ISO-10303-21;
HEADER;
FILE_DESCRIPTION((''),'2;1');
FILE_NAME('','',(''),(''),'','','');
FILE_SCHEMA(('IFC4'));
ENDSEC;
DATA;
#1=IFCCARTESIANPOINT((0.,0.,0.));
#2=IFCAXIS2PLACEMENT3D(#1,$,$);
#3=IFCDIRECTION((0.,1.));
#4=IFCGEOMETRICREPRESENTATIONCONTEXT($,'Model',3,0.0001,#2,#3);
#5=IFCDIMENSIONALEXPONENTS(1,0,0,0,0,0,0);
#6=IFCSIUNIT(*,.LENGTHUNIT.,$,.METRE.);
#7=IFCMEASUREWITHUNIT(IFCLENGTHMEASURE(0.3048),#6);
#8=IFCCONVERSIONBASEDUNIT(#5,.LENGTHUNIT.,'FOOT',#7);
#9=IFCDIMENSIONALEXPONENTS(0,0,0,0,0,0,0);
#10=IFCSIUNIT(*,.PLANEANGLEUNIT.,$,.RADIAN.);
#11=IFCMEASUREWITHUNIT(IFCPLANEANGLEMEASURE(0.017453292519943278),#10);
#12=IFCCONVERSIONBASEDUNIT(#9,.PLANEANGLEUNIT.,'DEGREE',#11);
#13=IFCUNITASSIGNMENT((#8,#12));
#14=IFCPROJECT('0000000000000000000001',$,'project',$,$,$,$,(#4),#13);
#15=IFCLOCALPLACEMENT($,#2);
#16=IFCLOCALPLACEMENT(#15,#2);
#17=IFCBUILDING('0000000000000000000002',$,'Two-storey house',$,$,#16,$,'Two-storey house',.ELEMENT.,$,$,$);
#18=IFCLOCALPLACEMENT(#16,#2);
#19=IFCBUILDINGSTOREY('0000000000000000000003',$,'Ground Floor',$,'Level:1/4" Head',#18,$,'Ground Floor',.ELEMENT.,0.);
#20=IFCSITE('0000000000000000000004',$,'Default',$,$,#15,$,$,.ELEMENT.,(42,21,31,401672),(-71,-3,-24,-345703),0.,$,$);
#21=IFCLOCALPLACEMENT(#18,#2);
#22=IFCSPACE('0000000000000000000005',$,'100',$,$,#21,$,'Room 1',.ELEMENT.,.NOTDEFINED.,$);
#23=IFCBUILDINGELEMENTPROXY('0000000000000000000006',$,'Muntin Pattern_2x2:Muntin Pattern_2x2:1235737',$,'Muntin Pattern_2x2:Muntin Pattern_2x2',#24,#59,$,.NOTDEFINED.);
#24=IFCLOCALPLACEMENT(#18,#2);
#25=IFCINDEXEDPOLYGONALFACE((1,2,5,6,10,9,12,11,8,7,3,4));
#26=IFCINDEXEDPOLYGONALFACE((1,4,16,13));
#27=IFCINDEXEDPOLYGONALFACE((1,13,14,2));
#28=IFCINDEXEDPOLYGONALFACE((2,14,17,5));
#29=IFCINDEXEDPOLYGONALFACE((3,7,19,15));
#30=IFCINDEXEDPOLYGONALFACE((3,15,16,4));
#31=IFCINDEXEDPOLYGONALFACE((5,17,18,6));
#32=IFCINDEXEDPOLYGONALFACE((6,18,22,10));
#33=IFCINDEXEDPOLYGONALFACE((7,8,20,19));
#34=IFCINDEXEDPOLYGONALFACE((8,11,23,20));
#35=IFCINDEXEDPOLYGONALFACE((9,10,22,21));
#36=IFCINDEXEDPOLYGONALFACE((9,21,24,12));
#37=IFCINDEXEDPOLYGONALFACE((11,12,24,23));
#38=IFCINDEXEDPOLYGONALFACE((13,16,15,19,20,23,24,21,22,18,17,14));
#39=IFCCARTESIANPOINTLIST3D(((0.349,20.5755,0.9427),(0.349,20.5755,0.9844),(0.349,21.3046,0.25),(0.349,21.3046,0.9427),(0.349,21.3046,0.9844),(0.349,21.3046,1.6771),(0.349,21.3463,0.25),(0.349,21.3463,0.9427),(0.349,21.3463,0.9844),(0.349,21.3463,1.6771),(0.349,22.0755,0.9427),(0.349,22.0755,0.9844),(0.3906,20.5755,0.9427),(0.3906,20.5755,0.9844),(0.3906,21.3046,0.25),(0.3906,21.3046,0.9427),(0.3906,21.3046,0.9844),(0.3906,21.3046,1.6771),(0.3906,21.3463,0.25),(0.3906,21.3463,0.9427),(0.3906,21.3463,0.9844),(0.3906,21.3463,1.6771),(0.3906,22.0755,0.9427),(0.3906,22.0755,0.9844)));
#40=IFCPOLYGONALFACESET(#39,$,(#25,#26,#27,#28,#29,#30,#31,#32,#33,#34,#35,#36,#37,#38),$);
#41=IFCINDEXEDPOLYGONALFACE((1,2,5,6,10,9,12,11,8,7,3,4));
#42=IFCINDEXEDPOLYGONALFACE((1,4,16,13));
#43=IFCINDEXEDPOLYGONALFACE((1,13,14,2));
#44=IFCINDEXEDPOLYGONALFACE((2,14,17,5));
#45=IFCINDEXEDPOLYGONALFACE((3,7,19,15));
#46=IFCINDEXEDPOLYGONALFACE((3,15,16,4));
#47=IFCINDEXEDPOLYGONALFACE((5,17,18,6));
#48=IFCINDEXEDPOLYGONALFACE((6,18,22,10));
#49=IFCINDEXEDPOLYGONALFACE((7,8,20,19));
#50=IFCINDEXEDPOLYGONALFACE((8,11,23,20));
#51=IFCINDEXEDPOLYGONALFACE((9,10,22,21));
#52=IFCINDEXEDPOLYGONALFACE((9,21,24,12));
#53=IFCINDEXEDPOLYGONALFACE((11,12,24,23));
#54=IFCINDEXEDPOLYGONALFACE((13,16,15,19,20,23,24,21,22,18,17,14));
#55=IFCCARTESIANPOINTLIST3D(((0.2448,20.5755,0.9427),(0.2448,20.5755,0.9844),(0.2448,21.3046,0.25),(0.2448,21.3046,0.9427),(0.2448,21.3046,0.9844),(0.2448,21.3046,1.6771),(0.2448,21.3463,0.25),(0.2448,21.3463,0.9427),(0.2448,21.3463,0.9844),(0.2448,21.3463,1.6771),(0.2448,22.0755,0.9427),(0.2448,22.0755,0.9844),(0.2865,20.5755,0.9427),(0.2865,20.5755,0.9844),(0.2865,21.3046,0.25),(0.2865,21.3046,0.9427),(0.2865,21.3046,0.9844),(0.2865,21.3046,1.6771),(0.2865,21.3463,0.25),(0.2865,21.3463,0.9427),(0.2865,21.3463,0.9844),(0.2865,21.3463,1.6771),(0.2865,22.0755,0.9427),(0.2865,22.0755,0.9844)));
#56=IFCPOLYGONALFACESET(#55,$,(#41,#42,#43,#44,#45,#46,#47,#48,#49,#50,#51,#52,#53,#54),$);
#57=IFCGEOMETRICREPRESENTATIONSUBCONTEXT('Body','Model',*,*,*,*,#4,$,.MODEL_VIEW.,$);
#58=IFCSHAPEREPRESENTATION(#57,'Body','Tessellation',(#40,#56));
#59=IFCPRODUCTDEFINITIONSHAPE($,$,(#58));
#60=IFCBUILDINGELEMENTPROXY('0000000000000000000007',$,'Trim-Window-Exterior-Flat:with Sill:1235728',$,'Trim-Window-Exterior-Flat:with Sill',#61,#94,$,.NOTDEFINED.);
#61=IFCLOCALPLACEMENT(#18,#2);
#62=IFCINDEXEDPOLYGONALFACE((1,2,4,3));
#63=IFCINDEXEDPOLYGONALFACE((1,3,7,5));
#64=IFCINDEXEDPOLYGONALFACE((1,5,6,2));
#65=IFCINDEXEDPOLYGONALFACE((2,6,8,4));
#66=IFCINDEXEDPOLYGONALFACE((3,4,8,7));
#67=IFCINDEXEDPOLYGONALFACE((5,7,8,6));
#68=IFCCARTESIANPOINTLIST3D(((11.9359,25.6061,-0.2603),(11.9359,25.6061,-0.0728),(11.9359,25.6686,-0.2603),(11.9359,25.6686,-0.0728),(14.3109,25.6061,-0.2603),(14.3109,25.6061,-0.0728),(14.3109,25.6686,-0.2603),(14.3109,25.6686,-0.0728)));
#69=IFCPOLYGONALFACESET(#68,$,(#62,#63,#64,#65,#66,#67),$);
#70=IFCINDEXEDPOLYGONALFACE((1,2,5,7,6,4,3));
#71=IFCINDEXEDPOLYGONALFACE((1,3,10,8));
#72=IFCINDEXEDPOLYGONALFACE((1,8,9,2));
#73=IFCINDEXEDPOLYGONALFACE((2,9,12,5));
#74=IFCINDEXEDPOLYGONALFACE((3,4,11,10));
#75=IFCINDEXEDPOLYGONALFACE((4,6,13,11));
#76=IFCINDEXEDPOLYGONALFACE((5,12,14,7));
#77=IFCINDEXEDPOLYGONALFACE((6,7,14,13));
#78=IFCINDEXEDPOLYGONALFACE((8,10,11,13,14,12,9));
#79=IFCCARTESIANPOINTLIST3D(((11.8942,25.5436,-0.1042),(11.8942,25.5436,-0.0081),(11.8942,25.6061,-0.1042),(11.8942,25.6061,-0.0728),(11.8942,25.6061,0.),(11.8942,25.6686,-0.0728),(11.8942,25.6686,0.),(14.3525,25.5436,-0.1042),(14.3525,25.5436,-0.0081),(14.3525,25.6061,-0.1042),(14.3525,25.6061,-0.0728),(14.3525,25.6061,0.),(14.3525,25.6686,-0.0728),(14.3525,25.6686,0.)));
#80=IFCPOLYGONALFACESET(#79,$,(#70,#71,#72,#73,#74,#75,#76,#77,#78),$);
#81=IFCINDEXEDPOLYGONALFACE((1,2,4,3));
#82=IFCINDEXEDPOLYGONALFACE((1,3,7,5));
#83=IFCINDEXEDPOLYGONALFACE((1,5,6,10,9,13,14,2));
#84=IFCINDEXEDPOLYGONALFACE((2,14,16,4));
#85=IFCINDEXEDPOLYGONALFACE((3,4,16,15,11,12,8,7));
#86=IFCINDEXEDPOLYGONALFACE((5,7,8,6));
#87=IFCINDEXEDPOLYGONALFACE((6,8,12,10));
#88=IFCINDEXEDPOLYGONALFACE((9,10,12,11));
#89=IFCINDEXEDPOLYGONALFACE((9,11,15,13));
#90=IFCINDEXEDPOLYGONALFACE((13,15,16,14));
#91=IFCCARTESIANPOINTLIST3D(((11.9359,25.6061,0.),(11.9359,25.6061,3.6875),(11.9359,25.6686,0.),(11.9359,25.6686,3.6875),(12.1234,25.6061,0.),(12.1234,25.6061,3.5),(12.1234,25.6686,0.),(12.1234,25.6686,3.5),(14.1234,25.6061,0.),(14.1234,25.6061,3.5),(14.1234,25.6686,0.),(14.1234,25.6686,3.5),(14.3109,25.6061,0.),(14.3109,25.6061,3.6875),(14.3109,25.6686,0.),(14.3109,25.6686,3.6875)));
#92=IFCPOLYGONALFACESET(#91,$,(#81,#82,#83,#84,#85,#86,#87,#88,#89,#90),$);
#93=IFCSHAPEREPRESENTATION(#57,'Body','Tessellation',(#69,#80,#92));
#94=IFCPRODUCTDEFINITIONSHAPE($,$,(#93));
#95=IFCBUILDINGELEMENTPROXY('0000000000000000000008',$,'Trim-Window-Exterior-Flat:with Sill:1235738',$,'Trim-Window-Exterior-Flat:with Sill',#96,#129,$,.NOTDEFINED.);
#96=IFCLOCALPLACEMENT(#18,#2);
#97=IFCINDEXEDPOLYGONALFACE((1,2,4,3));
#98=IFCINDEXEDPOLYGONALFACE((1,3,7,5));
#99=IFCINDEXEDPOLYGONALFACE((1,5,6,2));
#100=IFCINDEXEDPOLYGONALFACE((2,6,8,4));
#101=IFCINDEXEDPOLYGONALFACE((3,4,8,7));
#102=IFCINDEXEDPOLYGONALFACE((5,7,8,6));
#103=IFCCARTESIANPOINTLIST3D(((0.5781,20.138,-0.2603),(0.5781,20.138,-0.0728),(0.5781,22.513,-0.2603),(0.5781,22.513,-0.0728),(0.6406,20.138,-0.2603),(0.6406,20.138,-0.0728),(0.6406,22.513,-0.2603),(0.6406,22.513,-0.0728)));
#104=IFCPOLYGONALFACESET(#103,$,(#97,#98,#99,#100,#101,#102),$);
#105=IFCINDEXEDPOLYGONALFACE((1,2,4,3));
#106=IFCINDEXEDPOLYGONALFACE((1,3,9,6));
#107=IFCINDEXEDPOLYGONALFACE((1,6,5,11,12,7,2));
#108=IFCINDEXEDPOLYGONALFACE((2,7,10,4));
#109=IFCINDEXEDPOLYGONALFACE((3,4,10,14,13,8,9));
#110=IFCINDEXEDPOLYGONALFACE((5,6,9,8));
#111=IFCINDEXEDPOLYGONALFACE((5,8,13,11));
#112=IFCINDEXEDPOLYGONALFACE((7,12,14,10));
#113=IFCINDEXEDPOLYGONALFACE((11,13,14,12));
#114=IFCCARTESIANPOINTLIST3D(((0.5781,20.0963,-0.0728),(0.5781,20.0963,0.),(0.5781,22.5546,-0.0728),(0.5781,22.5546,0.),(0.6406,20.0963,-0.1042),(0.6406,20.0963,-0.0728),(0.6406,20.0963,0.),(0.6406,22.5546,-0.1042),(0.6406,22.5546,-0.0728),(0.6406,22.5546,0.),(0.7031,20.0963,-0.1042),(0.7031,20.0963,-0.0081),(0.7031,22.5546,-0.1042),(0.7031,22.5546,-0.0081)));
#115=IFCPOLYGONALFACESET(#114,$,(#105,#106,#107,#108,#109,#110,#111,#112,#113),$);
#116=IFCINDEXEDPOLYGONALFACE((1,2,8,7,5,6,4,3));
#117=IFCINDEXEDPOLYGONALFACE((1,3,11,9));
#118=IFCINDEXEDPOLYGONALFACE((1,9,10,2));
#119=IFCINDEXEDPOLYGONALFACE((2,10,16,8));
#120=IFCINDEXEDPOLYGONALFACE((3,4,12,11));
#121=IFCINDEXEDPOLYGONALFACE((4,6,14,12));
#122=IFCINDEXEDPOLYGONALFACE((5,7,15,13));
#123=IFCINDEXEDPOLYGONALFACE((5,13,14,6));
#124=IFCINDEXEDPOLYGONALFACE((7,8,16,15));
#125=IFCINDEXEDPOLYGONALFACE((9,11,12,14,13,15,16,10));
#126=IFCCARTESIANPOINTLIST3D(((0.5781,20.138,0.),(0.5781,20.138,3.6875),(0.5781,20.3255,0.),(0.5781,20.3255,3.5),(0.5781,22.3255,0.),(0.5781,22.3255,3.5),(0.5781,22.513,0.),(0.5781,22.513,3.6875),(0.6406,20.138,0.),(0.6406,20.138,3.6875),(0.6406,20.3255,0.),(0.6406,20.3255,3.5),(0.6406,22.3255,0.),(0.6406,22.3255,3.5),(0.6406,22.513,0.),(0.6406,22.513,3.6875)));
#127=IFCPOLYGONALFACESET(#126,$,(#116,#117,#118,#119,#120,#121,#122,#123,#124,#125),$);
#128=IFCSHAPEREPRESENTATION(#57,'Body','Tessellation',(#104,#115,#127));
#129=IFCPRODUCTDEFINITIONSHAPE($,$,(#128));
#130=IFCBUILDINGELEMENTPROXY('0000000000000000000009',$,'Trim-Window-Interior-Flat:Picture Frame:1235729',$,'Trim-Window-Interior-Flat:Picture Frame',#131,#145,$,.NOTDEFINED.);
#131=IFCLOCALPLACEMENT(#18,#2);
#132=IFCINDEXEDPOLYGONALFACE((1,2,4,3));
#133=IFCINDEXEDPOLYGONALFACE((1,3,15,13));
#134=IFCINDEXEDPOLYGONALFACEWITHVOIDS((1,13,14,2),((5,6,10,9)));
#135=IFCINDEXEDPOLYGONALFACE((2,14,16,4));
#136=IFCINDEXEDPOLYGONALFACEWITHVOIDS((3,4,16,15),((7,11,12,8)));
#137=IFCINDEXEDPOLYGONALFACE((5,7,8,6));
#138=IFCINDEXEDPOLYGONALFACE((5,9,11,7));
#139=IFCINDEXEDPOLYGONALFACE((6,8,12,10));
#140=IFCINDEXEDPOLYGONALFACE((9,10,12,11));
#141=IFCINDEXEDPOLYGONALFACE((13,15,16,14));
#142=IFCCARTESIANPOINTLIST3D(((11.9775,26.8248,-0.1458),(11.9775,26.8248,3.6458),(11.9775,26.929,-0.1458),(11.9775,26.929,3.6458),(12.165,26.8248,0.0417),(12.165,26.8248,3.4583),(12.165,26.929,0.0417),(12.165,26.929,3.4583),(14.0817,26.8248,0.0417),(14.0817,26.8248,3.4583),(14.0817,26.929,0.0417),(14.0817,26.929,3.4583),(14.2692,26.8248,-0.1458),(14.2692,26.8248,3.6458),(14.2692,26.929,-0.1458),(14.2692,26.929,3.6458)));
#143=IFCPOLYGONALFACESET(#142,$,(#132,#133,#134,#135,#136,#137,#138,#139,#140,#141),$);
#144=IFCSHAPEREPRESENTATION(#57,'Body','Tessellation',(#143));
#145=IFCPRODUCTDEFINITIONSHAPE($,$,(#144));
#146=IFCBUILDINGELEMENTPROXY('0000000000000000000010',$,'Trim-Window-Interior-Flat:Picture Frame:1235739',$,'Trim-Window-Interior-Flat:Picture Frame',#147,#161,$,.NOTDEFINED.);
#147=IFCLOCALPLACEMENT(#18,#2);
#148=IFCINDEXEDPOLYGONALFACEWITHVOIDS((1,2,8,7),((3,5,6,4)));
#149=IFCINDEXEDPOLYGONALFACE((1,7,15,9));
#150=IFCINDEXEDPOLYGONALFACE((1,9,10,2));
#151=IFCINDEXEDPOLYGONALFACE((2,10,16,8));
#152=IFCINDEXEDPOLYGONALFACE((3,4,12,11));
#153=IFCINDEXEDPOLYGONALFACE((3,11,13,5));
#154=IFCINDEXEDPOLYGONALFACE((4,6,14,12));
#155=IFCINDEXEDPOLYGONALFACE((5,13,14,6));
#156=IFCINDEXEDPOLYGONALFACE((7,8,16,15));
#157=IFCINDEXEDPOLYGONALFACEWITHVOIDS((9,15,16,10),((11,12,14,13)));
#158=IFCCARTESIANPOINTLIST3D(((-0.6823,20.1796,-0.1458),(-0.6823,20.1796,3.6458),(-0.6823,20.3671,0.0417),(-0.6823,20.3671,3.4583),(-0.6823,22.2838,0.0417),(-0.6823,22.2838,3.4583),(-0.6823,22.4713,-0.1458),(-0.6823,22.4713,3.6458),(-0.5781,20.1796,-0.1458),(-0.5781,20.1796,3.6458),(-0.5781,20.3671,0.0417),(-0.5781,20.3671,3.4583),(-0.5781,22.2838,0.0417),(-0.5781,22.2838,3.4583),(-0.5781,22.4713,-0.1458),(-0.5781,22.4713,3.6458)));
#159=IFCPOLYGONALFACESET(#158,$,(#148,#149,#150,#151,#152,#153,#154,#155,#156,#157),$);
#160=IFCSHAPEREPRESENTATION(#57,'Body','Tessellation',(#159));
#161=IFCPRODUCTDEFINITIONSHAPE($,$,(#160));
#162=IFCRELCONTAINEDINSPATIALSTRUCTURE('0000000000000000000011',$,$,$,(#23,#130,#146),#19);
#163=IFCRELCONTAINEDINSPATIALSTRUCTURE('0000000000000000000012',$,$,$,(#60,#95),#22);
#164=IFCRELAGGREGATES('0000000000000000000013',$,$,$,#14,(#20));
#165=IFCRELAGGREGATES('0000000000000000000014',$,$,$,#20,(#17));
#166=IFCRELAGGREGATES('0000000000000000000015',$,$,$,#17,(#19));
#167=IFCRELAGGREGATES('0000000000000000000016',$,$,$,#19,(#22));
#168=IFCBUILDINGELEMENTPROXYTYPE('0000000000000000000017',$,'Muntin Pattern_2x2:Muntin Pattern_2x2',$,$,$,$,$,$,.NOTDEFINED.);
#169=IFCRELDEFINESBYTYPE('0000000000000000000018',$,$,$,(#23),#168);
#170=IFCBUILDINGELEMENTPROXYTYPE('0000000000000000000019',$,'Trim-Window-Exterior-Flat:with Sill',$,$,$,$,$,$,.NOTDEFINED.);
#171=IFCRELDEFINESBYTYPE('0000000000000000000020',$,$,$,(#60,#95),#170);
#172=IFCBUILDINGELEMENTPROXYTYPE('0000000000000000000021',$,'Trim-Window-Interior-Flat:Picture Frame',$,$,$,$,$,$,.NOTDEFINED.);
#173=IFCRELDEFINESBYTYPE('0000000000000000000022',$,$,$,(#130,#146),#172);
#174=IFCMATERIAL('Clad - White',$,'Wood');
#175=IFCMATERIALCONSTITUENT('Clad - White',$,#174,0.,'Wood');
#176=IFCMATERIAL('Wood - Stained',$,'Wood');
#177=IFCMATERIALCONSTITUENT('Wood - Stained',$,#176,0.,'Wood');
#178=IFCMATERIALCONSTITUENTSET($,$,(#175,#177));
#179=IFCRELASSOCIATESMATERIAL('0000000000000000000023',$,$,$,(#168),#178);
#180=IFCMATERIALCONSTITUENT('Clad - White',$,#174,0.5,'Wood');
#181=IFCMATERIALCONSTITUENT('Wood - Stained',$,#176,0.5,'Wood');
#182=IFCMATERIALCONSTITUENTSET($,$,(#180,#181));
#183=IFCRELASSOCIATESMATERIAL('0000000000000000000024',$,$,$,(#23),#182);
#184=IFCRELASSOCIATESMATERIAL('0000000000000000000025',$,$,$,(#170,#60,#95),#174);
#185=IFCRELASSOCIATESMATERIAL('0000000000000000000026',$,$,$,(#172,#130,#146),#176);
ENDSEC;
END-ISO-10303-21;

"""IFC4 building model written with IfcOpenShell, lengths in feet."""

from ifc_helpers import new_model, entity, si_unit, converted_unit, direction, frame, origin, place, context, subcontext, project, spatial, indexed_curve, outline, extrude, source, transform, mapped, material, constituent, constituent_set, type_object, type_shapes, element, save


model = new_model("IFC4")

# Units and contexts
model_context = context("Model", 3, precision=0.0001, world=origin(), true_north=direction((0.0, 1.0)))
body_context = subcontext(model_context, "Body", "Model", "MODEL_VIEW")
ifc_project = project(units=[converted_unit("LENGTHUNIT", "FOOT", entity("IfcLengthMeasure", 0.3048), si_unit("LENGTHUNIT", "METRE"), dimensions=[1, 0, 0, 0, 0, 0, 0]), converted_unit("PLANEANGLEUNIT", "DEGREE", entity("IfcPlaneAngleMeasure", 0.017453292519943278), si_unit("PLANEANGLEUNIT", "RADIAN"), dimensions=[0, 0, 0, 0, 0, 0, 0])], contexts=[model_context])

# Site, building, storey
site_placement = place(None, origin())
site = spatial("IfcSite", under=ifc_project, at=site_placement, Name="Default", CompositionType="ELEMENT", RefLatitude=(42, 21, 31, 401672), RefLongitude=(-71, -3, -24, -345703), RefElevation=0.0)
building_placement = place(site_placement, origin())
building = spatial("IfcBuilding", under=site, at=building_placement, Name="Two-storey house", LongName="Two-storey house", CompositionType="ELEMENT")
storey_placement = place(building_placement, origin())
storey = spatial("IfcBuildingStorey", under=building, at=storey_placement, Name="Ground Floor", ObjectType="Level:1/4\" Head", LongName="Ground Floor", CompositionType="ELEMENT", Elevation=0.0)

# Shared definitions
ifc_material_1 = material(Name="Wood - Stained", Category="Wood")

# Building element proxy
ifc_material_2 = material(Name="Clad - White", Category="Wood")
ifc_constituent_1 = constituent(ifc_material_2, Name="Clad - White", Category="Wood", fraction=0.0)
ifc_constituent_2 = constituent(ifc_material_1, Name="Wood - Stained", Category="Wood", fraction=0.0)
ifc_constituent_set_1 = constituent_set(constituents=[ifc_constituent_1, ifc_constituent_2])
building_element_proxy_type_1 = type_object("IfcBuildingElementProxyType", Name="Muntin Pattern_2x2:Muntin Pattern_2x2", PredefinedType="NOTDEFINED", material=ifc_constituent_set_1)
shared_shape_1 = source(origin(), body_context, "Body", "SweptSolid", [
    extrude(outline(indexed_curve([(0.0208, -0.0208), (0.7135, -0.0208), (0.7135, 0.0208), (0.0208, 0.0208), (0.0208, 0.75), (-0.0208, 0.75), (-0.0208, 0.0208), (-0.7135, 0.0208), (-0.7135, -0.0208), (-0.0208, -0.0208), (-0.0208, -0.75), (0.0208, -0.75), (0.0208, -0.0208)], self_intersect=False)), frame((0.0, 0.0312, 0.7135), z_axis=(0.0, 1.0, 0.0), x_axis=(0.0, 0.0, 1.0)), (0.0, 0.0, 1.0), 0.0417),
    extrude(outline(indexed_curve([(0.0208, -0.0208), (0.7135, -0.0208), (0.7135, 0.0208), (0.0208, 0.0208), (0.0208, 0.75), (-0.0208, 0.75), (-0.0208, 0.0208), (-0.7135, 0.0208), (-0.7135, -0.0208), (-0.0208, -0.0208), (-0.0208, -0.75), (0.0208, -0.75), (0.0208, -0.0208)], self_intersect=False)), frame((0.0, -0.0729, 0.7135), z_axis=(0.0, 1.0, 0.0), x_axis=(0.0, 0.0, 1.0)), (0.0, 0.0, 1.0), 0.0417),
])
type_shapes(building_element_proxy_type_1, [shared_shape_1])
ifc_constituent_3 = constituent(ifc_material_2, Name="Clad - White", Category="Wood", fraction=0.5)
ifc_constituent_4 = constituent(ifc_material_1, Name="Wood - Stained", Category="Wood", fraction=0.5)
ifc_constituent_set_2 = constituent_set(constituents=[ifc_constituent_3, ifc_constituent_4])
proxy_1_placement = place(storey_placement, frame((0.3177, 21.3255, 0.25), z_axis=(0.0, 0.0, 1.0), x_axis=(0.0, -1.0, 0.0)))
element("IfcBuildingElementProxy", 1, at=proxy_1_placement, inside=storey, type_object=building_element_proxy_type_1, material=ifc_constituent_set_2, Name="Muntin Pattern_2x2:Muntin Pattern_2x2:1235737", ObjectType="Muntin Pattern_2x2:Muntin Pattern_2x2", PredefinedType="NOTDEFINED", context=body_context, shape_type="MappedRepresentation", body=[
    mapped(shared_shape_1, transform((0.0, 0.0, 0.0), scale=1.0)),
])

# Shared definitions
space_placement = place(storey_placement, origin())
space = spatial("IfcSpace", under=storey, at=space_placement, Name="100", LongName="Room 1", CompositionType="ELEMENT", PredefinedType="NOTDEFINED")

# Building element proxies
building_element_proxy_type_2 = type_object("IfcBuildingElementProxyType", Name="Trim-Window-Exterior-Flat:with Sill", PredefinedType="NOTDEFINED", material=ifc_material_2)
shared_shape_2 = source(origin(), body_context, "Body", "SweptSolid", [
    extrude(outline(indexed_curve([(-1.1875, -0.0938), (1.1875, -0.0938), (1.1875, 0.0938), (-1.1875, 0.0938), (-1.1875, -0.0938)], self_intersect=False)), frame((0.0, -3.6665, 0.0), z_axis=(0.0, 0.0, 1.0), x_axis=(-1.0, 0.0, 0.0)), (0.0, 0.0, 1.0), 0.0625),
    extrude(outline(indexed_curve([(-0.0625, -0.0525), (0.0, -0.0525), (0.0, -0.0211), (0.0625, -0.0211), (0.0625, 0.0517), (0.0, 0.0517), (-0.0625, 0.0436), (-0.0625, -0.0525)], self_intersect=False)), frame((-1.2292, -3.5517, 0.0625), z_axis=(1.0, 0.0, 0.0), x_axis=(0.0, 0.0, -1.0)), (0.0, 0.0, 1.0), 2.4583),
    extrude(outline(indexed_curve([(-1.8906, -1.1875), (1.7969, -1.1875), (1.7969, -1.0), (-1.7031, -1.0), (-1.7031, 1.0), (1.7969, 1.0), (1.7969, 1.1875), (-1.8906, 1.1875), (-1.8906, -1.1875)], self_intersect=False)), frame((0.0, -1.7031, 0.0), z_axis=(0.0, 0.0, 1.0), x_axis=(0.0, -1.0, 0.0)), (0.0, 0.0, 1.0), 0.0625),
])
type_shapes(building_element_proxy_type_2, [shared_shape_2])
for number, where, z_axis, x_axis, name in (
    (2, (13.1234, 25.6686, 3.5), (0.0, -1.0, 0.0), (1.0, 0.0, 0.0), "Trim-Window-Exterior-Flat:with Sill:1235728"),
    (3, (0.5781, 21.3255, 3.5), (1.0, 0.0, 0.0), (0.0, 1.0, 0.0), "Trim-Window-Exterior-Flat:with Sill:1235738"),
):
    element("IfcBuildingElementProxy", number, at=place(space_placement, frame(where, z_axis=z_axis, x_axis=x_axis)), inside=space, type_object=building_element_proxy_type_2, material=ifc_material_2, Name=name, ObjectType="Trim-Window-Exterior-Flat:with Sill", PredefinedType="NOTDEFINED", context=body_context, shape_type="MappedRepresentation", body=[
        mapped(shared_shape_2, transform((0.0, 0.0, 0.0), scale=1.0)),
    ])
building_element_proxy_type_3 = type_object("IfcBuildingElementProxyType", Name="Trim-Window-Interior-Flat:Picture Frame", PredefinedType="NOTDEFINED", material=ifc_material_1)
shared_shape_3 = source(origin(), body_context, "Body", "SweptSolid", [
    extrude(outline(indexed_curve([(-1.1458, -1.8958), (1.1458, -1.8958), (1.1458, 1.8958), (-1.1458, 1.8958), (-1.1458, -1.8958)], self_intersect=False), holes=[indexed_curve([(-0.9583, -1.7083), (-0.9583, 1.7083), (0.9583, 1.7083), (0.9583, -1.7083), (-0.9583, -1.7083)], self_intersect=False)]), frame((0.0, -1.75, 0.0), z_axis=(0.0, 0.0, 1.0), x_axis=(-1.0, 0.0, 0.0)), (0.0, 0.0, 1.0), 0.1042),
])
type_shapes(building_element_proxy_type_3, [shared_shape_3])
for number, where, z_axis, x_axis, name in (
    (4, (13.1234, 26.8248, 3.5), (0.0, 1.0, 0.0), (-1.0, 0.0, 0.0), "Trim-Window-Interior-Flat:Picture Frame:1235729"),
    (5, (-0.5781, 21.3255, 3.5), (-1.0, 0.0, 0.0), (0.0, -1.0, 0.0), "Trim-Window-Interior-Flat:Picture Frame:1235739"),
):
    element("IfcBuildingElementProxy", number, at=place(storey_placement, frame(where, z_axis=z_axis, x_axis=x_axis)), inside=storey, type_object=building_element_proxy_type_3, material=ifc_material_1, Name=name, ObjectType="Trim-Window-Interior-Flat:Picture Frame", PredefinedType="NOTDEFINED", context=body_context, shape_type="MappedRepresentation", body=[
        mapped(shared_shape_3, transform((0.0, 0.0, 0.0), scale=1.0)),
    ])

save(model, "model.ifc")
